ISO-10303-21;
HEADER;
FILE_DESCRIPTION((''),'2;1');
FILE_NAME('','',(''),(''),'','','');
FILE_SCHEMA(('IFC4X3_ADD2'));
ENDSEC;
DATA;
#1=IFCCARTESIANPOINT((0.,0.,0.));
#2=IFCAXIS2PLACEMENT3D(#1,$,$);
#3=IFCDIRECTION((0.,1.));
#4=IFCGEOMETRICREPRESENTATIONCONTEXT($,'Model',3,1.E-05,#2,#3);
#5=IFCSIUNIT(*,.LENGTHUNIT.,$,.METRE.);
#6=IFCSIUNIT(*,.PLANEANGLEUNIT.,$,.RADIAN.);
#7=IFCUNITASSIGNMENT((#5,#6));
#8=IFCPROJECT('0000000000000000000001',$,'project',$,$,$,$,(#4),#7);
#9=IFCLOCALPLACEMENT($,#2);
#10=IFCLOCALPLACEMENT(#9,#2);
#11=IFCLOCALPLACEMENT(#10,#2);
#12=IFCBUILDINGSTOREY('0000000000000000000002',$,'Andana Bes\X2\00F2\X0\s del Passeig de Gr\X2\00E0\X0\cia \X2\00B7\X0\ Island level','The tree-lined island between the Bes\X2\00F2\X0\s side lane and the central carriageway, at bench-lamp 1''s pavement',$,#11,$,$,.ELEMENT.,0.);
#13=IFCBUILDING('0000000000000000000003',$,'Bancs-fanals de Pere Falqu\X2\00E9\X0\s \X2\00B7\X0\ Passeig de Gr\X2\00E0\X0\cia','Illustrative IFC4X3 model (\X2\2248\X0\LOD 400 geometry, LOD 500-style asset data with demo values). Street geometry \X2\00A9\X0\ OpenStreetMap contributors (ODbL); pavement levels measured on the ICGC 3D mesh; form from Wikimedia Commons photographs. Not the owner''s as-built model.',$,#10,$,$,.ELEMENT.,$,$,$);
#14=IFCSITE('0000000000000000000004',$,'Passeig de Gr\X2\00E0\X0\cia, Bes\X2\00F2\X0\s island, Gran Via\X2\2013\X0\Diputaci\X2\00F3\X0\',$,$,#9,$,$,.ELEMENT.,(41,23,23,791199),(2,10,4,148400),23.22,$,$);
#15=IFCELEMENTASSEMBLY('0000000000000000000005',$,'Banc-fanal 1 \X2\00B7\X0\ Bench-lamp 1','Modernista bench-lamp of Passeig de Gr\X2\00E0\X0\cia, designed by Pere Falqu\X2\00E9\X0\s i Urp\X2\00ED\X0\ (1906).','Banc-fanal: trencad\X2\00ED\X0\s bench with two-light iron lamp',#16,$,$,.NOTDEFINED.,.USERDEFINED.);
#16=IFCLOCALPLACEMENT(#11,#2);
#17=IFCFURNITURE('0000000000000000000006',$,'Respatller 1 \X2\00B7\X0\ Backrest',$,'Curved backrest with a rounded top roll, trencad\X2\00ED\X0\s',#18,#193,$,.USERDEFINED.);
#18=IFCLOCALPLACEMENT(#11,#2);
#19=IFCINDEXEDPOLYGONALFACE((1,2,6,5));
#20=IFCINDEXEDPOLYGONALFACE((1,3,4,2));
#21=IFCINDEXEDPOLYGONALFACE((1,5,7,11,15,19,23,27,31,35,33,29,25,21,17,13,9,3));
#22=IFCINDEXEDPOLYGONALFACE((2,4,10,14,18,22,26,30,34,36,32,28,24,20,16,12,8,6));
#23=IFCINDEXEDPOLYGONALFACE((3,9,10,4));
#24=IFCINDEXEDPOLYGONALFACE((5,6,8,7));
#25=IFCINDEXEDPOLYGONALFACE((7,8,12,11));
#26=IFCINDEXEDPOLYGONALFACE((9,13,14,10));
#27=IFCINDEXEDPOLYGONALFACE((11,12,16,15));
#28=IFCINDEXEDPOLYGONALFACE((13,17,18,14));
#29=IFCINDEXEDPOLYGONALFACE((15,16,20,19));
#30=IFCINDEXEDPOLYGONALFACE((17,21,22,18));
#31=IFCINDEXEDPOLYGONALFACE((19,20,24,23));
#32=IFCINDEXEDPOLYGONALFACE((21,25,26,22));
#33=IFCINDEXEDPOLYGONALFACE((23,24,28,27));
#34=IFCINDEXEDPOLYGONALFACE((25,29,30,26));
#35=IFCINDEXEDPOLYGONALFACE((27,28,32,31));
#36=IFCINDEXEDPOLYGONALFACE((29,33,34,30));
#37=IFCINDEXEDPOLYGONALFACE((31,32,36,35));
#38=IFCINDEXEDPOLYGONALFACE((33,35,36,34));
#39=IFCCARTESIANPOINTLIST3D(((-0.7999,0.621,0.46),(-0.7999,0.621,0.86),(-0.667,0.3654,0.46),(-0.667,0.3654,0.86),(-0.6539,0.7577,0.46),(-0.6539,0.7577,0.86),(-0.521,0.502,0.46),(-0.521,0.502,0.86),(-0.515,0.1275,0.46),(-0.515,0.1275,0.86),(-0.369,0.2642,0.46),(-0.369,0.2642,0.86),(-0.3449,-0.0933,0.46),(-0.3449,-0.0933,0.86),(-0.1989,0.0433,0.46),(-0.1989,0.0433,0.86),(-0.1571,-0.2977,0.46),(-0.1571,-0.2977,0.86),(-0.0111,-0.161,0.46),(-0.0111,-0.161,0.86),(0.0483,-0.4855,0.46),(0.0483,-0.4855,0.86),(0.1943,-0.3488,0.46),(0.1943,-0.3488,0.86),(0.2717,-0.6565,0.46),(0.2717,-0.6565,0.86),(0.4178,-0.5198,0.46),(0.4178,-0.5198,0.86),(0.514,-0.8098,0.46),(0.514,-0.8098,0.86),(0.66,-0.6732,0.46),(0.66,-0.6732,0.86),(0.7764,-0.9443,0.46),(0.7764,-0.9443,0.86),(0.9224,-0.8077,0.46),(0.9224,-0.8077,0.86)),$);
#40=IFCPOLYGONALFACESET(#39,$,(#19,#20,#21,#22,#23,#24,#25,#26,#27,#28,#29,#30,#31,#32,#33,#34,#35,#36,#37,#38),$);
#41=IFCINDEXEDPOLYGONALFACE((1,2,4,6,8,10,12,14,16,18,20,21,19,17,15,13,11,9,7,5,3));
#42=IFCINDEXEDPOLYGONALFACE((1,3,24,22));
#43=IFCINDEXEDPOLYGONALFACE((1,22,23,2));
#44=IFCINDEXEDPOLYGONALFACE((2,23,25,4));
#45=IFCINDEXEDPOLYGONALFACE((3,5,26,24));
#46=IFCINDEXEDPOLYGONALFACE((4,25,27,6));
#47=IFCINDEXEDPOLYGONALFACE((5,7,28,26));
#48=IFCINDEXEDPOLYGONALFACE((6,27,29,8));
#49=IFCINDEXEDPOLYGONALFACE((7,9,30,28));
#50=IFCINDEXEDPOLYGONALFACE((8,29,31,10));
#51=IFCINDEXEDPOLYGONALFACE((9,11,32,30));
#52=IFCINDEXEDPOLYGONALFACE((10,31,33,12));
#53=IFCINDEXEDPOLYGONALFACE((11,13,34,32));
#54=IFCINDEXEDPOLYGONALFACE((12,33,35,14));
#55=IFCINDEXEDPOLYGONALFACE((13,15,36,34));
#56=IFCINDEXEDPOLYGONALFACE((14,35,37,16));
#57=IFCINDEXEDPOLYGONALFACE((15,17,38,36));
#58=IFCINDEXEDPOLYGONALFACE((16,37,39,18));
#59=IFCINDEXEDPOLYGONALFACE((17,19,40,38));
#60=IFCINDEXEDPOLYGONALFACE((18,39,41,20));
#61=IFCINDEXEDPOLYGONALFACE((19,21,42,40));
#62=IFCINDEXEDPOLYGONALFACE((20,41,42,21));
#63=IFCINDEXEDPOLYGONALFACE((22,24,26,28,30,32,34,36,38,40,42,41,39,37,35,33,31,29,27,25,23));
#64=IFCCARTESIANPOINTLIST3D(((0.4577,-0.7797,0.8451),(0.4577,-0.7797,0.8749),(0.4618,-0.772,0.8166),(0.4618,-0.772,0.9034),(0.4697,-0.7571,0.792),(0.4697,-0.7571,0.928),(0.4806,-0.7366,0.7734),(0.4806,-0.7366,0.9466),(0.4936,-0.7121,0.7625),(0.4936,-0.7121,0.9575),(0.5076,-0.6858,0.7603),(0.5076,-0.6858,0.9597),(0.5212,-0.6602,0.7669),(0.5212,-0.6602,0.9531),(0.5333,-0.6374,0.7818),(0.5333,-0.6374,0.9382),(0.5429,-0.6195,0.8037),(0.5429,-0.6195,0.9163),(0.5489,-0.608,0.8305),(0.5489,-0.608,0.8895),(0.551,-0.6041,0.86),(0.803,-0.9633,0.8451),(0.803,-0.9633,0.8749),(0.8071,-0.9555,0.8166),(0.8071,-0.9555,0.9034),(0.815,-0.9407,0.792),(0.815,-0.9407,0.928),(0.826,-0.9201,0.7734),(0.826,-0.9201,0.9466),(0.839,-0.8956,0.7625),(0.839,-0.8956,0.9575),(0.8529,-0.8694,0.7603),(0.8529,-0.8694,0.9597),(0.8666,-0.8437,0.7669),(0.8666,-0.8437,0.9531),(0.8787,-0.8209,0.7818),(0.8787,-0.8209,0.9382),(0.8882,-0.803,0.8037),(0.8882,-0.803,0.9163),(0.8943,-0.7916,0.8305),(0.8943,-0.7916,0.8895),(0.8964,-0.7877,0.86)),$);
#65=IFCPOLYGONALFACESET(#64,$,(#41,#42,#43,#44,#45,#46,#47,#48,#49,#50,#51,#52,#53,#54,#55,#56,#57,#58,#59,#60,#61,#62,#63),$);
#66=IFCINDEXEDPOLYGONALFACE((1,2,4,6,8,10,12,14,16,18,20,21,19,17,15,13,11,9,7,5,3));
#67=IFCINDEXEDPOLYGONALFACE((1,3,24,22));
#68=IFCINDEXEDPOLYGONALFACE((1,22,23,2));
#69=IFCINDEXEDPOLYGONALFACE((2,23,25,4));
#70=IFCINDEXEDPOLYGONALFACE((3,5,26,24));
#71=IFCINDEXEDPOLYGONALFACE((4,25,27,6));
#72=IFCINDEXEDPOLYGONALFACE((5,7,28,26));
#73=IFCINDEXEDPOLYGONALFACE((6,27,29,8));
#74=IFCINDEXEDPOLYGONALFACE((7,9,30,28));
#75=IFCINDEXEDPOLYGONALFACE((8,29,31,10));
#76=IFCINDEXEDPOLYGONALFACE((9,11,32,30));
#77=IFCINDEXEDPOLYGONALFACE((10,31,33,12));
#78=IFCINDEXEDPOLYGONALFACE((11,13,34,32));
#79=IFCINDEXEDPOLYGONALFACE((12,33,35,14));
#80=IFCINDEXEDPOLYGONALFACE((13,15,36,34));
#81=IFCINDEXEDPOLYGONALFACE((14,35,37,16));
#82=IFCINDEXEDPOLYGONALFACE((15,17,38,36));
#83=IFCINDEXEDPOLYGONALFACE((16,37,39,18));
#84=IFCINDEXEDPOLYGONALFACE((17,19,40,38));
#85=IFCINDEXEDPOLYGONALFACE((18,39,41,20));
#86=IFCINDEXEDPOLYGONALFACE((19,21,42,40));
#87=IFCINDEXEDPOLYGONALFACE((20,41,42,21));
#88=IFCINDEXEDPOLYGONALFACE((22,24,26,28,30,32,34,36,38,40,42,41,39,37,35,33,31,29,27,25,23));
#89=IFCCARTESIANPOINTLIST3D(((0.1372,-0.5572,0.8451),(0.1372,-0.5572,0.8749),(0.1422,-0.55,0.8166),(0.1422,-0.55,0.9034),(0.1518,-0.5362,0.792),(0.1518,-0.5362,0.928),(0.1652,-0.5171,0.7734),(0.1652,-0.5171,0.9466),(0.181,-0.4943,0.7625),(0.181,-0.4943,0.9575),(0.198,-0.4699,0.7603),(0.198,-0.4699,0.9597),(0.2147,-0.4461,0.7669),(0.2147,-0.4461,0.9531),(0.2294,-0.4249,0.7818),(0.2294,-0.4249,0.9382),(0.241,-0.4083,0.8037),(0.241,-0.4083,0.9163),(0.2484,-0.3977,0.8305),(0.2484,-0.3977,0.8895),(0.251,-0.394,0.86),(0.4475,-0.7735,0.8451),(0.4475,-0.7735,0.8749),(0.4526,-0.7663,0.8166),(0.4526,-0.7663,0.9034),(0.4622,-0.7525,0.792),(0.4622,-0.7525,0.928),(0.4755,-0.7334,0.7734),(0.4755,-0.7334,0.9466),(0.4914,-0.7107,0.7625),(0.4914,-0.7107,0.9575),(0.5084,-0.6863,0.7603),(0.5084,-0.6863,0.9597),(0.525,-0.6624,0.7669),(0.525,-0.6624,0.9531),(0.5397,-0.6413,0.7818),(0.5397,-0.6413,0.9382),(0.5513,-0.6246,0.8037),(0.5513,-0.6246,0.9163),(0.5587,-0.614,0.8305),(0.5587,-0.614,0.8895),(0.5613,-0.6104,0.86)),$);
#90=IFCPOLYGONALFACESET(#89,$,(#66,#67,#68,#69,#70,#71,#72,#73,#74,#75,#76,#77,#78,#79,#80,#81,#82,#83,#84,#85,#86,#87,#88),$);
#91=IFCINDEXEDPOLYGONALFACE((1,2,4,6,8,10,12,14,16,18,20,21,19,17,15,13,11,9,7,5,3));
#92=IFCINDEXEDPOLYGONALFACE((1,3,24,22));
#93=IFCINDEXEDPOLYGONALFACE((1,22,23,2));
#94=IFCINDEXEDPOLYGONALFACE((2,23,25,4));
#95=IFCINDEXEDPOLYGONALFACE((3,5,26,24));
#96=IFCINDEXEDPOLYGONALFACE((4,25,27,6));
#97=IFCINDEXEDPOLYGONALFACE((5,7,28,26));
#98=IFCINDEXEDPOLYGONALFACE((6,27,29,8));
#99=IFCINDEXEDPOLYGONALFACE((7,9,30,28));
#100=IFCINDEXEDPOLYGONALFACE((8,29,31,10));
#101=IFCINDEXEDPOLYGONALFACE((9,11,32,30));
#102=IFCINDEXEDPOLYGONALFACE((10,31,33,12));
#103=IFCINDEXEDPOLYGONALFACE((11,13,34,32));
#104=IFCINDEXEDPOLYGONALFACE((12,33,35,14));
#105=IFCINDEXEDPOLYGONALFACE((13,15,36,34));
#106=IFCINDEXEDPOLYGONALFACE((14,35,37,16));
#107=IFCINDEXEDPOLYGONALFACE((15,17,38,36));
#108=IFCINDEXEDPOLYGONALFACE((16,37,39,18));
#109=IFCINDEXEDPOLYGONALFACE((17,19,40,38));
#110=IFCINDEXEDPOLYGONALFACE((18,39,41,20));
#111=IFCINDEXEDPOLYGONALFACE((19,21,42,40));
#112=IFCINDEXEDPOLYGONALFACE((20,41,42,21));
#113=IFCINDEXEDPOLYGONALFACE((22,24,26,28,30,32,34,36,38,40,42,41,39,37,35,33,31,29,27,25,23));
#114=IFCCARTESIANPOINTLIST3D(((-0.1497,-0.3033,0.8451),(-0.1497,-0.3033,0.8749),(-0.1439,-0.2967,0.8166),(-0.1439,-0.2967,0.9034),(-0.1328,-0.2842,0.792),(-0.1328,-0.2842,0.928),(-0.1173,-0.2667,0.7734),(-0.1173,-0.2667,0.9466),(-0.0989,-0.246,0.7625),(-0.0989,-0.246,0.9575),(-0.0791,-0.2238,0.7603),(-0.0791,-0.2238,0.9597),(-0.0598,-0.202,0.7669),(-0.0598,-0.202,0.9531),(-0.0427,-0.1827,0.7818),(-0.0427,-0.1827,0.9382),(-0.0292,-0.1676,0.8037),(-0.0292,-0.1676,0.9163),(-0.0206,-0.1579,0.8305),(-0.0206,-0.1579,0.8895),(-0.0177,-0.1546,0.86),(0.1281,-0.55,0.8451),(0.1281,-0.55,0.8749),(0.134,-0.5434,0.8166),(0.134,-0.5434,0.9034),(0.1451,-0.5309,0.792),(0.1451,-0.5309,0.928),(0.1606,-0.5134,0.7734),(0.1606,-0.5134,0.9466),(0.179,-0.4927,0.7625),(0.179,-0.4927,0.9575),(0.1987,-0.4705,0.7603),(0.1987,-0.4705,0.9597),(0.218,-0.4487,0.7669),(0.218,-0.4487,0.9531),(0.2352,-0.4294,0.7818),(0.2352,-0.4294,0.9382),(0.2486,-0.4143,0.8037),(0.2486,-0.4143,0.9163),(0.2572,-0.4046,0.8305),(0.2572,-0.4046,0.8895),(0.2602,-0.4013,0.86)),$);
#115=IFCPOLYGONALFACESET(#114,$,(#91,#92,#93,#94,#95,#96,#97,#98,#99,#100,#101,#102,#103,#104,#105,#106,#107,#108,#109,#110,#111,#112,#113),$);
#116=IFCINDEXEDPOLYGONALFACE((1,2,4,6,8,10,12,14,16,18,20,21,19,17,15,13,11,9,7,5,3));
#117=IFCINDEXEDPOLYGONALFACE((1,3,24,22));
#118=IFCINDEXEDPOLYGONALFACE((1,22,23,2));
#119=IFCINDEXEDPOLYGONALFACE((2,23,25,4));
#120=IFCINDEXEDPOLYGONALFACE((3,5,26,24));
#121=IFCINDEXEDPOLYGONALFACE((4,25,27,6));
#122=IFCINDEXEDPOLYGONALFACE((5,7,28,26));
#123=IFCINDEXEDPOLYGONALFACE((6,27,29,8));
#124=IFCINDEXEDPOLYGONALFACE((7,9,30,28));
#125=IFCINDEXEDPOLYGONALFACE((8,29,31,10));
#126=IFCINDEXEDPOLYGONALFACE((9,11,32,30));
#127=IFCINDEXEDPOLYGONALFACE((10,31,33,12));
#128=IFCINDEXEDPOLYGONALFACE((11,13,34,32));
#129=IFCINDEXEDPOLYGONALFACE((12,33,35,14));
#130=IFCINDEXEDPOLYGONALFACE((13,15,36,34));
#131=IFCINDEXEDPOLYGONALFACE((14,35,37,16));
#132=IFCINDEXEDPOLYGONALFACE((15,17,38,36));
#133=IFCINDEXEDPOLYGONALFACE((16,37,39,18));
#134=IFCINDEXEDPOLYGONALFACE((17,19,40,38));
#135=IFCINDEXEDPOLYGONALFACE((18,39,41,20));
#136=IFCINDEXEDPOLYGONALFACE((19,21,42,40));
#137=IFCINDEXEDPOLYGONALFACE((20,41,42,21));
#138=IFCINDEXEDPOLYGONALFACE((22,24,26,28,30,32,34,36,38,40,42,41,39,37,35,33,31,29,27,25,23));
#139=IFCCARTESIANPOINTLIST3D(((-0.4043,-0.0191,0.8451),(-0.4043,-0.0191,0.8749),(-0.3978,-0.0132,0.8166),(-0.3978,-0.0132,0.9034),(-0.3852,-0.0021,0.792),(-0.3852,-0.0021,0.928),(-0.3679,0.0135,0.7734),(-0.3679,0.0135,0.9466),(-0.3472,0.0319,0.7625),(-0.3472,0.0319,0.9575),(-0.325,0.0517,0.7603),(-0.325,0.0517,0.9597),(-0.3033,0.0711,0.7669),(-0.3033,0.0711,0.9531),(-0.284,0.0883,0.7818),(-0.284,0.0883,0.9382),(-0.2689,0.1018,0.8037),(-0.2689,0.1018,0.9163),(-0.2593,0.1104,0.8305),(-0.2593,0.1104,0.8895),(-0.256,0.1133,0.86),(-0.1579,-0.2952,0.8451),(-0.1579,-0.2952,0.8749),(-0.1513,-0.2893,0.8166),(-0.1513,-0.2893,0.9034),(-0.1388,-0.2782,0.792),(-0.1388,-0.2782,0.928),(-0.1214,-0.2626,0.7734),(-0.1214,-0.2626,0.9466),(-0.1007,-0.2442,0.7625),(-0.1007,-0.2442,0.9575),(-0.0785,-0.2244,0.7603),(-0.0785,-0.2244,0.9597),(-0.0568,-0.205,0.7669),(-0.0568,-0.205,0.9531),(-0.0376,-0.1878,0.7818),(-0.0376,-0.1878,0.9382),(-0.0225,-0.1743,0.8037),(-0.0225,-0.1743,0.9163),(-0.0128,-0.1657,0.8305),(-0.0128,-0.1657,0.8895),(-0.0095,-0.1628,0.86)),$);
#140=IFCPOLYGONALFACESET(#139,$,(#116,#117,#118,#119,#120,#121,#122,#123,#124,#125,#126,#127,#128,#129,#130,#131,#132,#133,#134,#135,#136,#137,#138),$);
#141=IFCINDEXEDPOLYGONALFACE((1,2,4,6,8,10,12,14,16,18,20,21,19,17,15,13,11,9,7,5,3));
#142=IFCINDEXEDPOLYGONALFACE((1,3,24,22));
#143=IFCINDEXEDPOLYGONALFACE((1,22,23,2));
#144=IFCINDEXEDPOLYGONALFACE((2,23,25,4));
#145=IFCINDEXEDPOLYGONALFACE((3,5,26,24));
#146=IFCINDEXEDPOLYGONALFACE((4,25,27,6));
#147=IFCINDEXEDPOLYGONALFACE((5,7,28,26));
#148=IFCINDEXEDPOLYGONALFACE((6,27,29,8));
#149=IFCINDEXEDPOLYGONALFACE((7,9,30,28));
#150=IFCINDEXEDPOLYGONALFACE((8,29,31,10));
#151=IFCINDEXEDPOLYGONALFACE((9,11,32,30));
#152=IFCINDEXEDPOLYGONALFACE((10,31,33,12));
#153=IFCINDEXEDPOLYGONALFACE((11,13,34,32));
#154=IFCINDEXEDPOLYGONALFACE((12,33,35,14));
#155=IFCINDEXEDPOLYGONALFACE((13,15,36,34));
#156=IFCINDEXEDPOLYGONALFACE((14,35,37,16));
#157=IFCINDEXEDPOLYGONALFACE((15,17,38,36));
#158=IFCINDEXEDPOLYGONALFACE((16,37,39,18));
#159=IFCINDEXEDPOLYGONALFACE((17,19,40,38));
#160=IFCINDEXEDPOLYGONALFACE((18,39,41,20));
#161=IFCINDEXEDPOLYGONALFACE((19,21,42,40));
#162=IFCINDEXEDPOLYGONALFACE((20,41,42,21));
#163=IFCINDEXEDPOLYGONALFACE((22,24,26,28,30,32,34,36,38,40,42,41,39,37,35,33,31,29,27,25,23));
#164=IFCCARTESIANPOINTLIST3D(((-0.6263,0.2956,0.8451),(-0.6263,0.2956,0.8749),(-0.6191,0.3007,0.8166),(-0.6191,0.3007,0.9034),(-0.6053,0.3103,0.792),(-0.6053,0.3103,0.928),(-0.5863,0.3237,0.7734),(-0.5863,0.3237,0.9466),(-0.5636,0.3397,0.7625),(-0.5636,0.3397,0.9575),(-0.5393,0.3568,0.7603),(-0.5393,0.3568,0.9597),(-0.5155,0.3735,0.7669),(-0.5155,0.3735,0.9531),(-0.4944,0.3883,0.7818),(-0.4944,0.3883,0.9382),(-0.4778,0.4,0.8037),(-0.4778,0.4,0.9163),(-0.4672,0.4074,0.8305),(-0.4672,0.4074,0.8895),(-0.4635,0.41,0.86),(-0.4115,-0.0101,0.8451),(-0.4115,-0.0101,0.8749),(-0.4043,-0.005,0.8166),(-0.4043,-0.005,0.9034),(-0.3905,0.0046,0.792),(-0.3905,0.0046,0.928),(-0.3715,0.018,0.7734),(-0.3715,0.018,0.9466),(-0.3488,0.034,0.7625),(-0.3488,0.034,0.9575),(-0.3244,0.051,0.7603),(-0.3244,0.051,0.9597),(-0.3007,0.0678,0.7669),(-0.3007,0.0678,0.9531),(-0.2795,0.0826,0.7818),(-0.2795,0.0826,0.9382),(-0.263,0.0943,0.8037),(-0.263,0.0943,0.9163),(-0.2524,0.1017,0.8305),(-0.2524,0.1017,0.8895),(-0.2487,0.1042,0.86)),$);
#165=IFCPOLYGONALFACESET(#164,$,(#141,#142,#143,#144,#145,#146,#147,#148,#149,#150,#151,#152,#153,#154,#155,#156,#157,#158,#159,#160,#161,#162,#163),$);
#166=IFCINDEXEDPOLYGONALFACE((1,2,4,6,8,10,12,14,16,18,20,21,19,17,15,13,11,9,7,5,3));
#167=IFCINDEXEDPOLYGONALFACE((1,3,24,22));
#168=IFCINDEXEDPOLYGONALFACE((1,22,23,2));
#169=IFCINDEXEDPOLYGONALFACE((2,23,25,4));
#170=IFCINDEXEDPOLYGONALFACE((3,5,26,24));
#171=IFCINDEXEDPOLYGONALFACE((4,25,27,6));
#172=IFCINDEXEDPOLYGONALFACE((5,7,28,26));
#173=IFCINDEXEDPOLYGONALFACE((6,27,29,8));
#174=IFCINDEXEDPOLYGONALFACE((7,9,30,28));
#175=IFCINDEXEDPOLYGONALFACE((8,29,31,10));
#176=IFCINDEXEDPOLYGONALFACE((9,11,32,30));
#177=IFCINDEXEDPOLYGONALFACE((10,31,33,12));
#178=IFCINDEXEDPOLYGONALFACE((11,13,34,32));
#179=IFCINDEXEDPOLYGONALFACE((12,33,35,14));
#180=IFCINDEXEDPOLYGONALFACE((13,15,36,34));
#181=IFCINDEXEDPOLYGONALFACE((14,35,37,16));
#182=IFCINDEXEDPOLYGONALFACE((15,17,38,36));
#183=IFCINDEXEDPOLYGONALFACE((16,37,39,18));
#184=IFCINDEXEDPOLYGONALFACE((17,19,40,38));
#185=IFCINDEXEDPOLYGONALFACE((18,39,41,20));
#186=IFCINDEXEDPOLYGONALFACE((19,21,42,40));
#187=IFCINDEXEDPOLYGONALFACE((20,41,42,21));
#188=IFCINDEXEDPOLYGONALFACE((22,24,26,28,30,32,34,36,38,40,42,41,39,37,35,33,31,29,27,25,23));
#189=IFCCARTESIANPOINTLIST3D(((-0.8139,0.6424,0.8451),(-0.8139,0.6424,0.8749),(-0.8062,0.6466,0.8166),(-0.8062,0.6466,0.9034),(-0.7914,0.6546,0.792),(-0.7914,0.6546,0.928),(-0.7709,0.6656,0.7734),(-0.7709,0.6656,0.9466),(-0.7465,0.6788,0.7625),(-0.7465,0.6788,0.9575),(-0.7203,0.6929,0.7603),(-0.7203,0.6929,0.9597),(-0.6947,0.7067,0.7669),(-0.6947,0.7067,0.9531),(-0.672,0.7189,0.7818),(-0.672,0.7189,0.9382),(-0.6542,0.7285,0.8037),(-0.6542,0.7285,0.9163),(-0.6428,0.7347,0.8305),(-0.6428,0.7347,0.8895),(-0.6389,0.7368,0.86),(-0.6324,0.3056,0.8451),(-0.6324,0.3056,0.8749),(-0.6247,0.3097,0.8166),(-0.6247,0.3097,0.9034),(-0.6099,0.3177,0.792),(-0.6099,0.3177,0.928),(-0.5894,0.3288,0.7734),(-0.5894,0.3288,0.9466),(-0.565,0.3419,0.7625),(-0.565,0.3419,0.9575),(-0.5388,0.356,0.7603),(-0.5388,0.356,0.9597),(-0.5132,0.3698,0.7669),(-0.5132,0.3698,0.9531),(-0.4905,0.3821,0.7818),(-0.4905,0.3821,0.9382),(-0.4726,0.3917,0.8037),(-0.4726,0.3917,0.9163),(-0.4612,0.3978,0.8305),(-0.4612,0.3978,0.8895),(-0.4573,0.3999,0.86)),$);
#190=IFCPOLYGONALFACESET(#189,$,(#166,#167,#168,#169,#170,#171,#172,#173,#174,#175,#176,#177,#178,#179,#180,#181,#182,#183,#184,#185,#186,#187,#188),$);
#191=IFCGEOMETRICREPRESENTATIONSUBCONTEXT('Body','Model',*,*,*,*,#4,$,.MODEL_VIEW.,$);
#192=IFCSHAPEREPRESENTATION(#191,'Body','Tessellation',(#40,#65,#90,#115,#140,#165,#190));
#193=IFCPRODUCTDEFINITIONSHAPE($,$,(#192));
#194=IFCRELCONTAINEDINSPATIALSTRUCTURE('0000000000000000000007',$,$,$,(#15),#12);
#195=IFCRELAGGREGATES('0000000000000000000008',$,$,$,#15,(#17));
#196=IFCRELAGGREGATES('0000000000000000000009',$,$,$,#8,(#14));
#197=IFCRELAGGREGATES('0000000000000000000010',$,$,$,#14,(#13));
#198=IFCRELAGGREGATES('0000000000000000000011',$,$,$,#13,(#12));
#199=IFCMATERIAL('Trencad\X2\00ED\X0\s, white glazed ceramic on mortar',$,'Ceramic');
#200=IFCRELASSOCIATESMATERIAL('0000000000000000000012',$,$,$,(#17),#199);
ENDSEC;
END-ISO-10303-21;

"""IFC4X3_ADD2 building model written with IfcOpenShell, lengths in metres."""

from ifc_helpers import new_model, si_unit, direction, frame, origin, origin_2d_with_axis, place, context, subcontext, project, spatial, polyline, circle, outline, extrude, material, element, aggregate, save


model = new_model("IFC4X3_ADD2")

# Units and contexts
model_context = context("Model", 3, precision=1e-05, world=origin(), true_north=direction((0.0, 1.0)))
body_context = subcontext(model_context, "Body", "Model", "MODEL_VIEW")
ifc_project = project(units=[si_unit("LENGTHUNIT", "METRE"), si_unit("PLANEANGLEUNIT", "RADIAN")], contexts=[model_context])

# Site, building, storey
site_placement = place(None, origin())
site = spatial("IfcSite", under=ifc_project, at=site_placement, Name="Passeig de Gràcia, Besòs island, Gran Via–Diputació", CompositionType="ELEMENT", RefLatitude=(41, 23, 23, 791199), RefLongitude=(2, 10, 4, 148400), RefElevation=23.22)
building_placement = place(site_placement, origin())
building = spatial("IfcBuilding", under=site, at=building_placement, Name="Bancs-fanals de Pere Falqués · Passeig de Gràcia", Description="Illustrative IFC4X3 model (≈LOD 400 geometry, LOD 500-style asset data with demo values). Street geometry © OpenStreetMap contributors (ODbL); pavement levels measured on the ICGC 3D mesh; form from Wikimedia Commons photographs. Not the owner's as-built model.", CompositionType="ELEMENT")
storey_placement = place(building_placement, origin())
storey = spatial("IfcBuildingStorey", under=building, at=storey_placement, Name="Andana Besòs del Passeig de Gràcia · Island level", Description="The tree-lined island between the Besòs side lane and the central carriageway, at bench-lamp 1's pavement", CompositionType="ELEMENT", Elevation=0.0)

# Element assembly
assembly_1_placement = place(building_placement, origin())
assembly_1 = element("IfcElementAssembly", 1, at=assembly_1_placement, inside=storey, Name="Banc-fanal 1 · Bench-lamp 1", Description="Modernista bench-lamp of Passeig de Gràcia, designed by Pere Falqués i Urpí (1906).", ObjectType="Banc-fanal: trencadís bench with two-light iron lamp", AssemblyPlace="NOTDEFINED", PredefinedType="USERDEFINED")

# Shared definitions
ifc_material_1 = material(Name="Trencadís, white glazed ceramic on mortar", Category="Ceramic")

# Furniture
furniture_1_placement = place(building_placement, origin())
furniture_1 = element("IfcFurniture", 2, at=furniture_1_placement, material=ifc_material_1, Name="Respatller 1 · Backrest", ObjectType="Curved backrest with a rounded top roll, trencadís", PredefinedType="USERDEFINED", context=body_context, shape_type="SweptSolid", body=[
    extrude(outline(polyline([(0.9224, -0.8077), (0.66, -0.6732), (0.4178, -0.5198), (0.1943, -0.3488), (-0.0111, -0.161), (-0.1989, 0.0433), (-0.369, 0.2642), (-0.521, 0.502), (-0.6539, 0.7577), (-0.7999, 0.621), (-0.667, 0.3654), (-0.515, 0.1275), (-0.3449, -0.0933), (-0.1571, -0.2977), (0.0483, -0.4855), (0.2717, -0.6565), (0.514, -0.8098), (0.7764, -0.9443), (0.9224, -0.8077)])), frame((0.0, 0.0, 0.46)), (0.0, 0.0, 1.0), 0.4),
    extrude(circle(Radius=0.1, at=origin_2d_with_axis()), frame((0.8494, -0.876, 0.86), z_axis=(-0.88301, 0.469354, 0.0), x_axis=(0.469354, 0.88301, 0.0)), (0.0, 0.0, 1.0), 0.3911),
    extrude(circle(Radius=0.1, at=origin_2d_with_axis()), frame((0.5041, -0.6924, 0.86), z_axis=(-0.820307, 0.571924, 0.0), x_axis=(0.571924, 0.820307, 0.0)), (0.0, 0.0, 1.0), 0.3783),
    extrude(circle(Radius=0.1, at=origin_2d_with_axis()), frame((0.1938, -0.4761, 0.86), z_axis=(-0.74778, 0.663947, 0.0), x_axis=(0.663947, 0.74778, 0.0)), (0.0, 0.0, 1.0), 0.3716),
    extrude(circle(Radius=0.1, at=origin_2d_with_axis()), frame((-0.0841, -0.2293, 0.86), z_axis=(-0.665944, 0.746002, 0.0), x_axis=(0.746002, 0.665944, 0.0)), (0.0, 0.0, 1.0), 0.3701),
    extrude(circle(Radius=0.1, at=origin_2d_with_axis()), frame((-0.3306, 0.0468, 0.86), z_axis=(-0.5749, 0.818223, 0.0), x_axis=(0.818223, 0.5749, 0.0)), (0.0, 0.0, 1.0), 0.3736),
    extrude(circle(Radius=0.1, at=origin_2d_with_axis()), frame((-0.5454, 0.3525, 0.86), z_axis=(-0.474363, 0.880329, 0.0), x_axis=(0.880329, 0.474363, 0.0)), (0.0, 0.0, 1.0), 0.3827),
])
aggregate(assembly_1, [furniture_1])

save(model, "model.ifc")
